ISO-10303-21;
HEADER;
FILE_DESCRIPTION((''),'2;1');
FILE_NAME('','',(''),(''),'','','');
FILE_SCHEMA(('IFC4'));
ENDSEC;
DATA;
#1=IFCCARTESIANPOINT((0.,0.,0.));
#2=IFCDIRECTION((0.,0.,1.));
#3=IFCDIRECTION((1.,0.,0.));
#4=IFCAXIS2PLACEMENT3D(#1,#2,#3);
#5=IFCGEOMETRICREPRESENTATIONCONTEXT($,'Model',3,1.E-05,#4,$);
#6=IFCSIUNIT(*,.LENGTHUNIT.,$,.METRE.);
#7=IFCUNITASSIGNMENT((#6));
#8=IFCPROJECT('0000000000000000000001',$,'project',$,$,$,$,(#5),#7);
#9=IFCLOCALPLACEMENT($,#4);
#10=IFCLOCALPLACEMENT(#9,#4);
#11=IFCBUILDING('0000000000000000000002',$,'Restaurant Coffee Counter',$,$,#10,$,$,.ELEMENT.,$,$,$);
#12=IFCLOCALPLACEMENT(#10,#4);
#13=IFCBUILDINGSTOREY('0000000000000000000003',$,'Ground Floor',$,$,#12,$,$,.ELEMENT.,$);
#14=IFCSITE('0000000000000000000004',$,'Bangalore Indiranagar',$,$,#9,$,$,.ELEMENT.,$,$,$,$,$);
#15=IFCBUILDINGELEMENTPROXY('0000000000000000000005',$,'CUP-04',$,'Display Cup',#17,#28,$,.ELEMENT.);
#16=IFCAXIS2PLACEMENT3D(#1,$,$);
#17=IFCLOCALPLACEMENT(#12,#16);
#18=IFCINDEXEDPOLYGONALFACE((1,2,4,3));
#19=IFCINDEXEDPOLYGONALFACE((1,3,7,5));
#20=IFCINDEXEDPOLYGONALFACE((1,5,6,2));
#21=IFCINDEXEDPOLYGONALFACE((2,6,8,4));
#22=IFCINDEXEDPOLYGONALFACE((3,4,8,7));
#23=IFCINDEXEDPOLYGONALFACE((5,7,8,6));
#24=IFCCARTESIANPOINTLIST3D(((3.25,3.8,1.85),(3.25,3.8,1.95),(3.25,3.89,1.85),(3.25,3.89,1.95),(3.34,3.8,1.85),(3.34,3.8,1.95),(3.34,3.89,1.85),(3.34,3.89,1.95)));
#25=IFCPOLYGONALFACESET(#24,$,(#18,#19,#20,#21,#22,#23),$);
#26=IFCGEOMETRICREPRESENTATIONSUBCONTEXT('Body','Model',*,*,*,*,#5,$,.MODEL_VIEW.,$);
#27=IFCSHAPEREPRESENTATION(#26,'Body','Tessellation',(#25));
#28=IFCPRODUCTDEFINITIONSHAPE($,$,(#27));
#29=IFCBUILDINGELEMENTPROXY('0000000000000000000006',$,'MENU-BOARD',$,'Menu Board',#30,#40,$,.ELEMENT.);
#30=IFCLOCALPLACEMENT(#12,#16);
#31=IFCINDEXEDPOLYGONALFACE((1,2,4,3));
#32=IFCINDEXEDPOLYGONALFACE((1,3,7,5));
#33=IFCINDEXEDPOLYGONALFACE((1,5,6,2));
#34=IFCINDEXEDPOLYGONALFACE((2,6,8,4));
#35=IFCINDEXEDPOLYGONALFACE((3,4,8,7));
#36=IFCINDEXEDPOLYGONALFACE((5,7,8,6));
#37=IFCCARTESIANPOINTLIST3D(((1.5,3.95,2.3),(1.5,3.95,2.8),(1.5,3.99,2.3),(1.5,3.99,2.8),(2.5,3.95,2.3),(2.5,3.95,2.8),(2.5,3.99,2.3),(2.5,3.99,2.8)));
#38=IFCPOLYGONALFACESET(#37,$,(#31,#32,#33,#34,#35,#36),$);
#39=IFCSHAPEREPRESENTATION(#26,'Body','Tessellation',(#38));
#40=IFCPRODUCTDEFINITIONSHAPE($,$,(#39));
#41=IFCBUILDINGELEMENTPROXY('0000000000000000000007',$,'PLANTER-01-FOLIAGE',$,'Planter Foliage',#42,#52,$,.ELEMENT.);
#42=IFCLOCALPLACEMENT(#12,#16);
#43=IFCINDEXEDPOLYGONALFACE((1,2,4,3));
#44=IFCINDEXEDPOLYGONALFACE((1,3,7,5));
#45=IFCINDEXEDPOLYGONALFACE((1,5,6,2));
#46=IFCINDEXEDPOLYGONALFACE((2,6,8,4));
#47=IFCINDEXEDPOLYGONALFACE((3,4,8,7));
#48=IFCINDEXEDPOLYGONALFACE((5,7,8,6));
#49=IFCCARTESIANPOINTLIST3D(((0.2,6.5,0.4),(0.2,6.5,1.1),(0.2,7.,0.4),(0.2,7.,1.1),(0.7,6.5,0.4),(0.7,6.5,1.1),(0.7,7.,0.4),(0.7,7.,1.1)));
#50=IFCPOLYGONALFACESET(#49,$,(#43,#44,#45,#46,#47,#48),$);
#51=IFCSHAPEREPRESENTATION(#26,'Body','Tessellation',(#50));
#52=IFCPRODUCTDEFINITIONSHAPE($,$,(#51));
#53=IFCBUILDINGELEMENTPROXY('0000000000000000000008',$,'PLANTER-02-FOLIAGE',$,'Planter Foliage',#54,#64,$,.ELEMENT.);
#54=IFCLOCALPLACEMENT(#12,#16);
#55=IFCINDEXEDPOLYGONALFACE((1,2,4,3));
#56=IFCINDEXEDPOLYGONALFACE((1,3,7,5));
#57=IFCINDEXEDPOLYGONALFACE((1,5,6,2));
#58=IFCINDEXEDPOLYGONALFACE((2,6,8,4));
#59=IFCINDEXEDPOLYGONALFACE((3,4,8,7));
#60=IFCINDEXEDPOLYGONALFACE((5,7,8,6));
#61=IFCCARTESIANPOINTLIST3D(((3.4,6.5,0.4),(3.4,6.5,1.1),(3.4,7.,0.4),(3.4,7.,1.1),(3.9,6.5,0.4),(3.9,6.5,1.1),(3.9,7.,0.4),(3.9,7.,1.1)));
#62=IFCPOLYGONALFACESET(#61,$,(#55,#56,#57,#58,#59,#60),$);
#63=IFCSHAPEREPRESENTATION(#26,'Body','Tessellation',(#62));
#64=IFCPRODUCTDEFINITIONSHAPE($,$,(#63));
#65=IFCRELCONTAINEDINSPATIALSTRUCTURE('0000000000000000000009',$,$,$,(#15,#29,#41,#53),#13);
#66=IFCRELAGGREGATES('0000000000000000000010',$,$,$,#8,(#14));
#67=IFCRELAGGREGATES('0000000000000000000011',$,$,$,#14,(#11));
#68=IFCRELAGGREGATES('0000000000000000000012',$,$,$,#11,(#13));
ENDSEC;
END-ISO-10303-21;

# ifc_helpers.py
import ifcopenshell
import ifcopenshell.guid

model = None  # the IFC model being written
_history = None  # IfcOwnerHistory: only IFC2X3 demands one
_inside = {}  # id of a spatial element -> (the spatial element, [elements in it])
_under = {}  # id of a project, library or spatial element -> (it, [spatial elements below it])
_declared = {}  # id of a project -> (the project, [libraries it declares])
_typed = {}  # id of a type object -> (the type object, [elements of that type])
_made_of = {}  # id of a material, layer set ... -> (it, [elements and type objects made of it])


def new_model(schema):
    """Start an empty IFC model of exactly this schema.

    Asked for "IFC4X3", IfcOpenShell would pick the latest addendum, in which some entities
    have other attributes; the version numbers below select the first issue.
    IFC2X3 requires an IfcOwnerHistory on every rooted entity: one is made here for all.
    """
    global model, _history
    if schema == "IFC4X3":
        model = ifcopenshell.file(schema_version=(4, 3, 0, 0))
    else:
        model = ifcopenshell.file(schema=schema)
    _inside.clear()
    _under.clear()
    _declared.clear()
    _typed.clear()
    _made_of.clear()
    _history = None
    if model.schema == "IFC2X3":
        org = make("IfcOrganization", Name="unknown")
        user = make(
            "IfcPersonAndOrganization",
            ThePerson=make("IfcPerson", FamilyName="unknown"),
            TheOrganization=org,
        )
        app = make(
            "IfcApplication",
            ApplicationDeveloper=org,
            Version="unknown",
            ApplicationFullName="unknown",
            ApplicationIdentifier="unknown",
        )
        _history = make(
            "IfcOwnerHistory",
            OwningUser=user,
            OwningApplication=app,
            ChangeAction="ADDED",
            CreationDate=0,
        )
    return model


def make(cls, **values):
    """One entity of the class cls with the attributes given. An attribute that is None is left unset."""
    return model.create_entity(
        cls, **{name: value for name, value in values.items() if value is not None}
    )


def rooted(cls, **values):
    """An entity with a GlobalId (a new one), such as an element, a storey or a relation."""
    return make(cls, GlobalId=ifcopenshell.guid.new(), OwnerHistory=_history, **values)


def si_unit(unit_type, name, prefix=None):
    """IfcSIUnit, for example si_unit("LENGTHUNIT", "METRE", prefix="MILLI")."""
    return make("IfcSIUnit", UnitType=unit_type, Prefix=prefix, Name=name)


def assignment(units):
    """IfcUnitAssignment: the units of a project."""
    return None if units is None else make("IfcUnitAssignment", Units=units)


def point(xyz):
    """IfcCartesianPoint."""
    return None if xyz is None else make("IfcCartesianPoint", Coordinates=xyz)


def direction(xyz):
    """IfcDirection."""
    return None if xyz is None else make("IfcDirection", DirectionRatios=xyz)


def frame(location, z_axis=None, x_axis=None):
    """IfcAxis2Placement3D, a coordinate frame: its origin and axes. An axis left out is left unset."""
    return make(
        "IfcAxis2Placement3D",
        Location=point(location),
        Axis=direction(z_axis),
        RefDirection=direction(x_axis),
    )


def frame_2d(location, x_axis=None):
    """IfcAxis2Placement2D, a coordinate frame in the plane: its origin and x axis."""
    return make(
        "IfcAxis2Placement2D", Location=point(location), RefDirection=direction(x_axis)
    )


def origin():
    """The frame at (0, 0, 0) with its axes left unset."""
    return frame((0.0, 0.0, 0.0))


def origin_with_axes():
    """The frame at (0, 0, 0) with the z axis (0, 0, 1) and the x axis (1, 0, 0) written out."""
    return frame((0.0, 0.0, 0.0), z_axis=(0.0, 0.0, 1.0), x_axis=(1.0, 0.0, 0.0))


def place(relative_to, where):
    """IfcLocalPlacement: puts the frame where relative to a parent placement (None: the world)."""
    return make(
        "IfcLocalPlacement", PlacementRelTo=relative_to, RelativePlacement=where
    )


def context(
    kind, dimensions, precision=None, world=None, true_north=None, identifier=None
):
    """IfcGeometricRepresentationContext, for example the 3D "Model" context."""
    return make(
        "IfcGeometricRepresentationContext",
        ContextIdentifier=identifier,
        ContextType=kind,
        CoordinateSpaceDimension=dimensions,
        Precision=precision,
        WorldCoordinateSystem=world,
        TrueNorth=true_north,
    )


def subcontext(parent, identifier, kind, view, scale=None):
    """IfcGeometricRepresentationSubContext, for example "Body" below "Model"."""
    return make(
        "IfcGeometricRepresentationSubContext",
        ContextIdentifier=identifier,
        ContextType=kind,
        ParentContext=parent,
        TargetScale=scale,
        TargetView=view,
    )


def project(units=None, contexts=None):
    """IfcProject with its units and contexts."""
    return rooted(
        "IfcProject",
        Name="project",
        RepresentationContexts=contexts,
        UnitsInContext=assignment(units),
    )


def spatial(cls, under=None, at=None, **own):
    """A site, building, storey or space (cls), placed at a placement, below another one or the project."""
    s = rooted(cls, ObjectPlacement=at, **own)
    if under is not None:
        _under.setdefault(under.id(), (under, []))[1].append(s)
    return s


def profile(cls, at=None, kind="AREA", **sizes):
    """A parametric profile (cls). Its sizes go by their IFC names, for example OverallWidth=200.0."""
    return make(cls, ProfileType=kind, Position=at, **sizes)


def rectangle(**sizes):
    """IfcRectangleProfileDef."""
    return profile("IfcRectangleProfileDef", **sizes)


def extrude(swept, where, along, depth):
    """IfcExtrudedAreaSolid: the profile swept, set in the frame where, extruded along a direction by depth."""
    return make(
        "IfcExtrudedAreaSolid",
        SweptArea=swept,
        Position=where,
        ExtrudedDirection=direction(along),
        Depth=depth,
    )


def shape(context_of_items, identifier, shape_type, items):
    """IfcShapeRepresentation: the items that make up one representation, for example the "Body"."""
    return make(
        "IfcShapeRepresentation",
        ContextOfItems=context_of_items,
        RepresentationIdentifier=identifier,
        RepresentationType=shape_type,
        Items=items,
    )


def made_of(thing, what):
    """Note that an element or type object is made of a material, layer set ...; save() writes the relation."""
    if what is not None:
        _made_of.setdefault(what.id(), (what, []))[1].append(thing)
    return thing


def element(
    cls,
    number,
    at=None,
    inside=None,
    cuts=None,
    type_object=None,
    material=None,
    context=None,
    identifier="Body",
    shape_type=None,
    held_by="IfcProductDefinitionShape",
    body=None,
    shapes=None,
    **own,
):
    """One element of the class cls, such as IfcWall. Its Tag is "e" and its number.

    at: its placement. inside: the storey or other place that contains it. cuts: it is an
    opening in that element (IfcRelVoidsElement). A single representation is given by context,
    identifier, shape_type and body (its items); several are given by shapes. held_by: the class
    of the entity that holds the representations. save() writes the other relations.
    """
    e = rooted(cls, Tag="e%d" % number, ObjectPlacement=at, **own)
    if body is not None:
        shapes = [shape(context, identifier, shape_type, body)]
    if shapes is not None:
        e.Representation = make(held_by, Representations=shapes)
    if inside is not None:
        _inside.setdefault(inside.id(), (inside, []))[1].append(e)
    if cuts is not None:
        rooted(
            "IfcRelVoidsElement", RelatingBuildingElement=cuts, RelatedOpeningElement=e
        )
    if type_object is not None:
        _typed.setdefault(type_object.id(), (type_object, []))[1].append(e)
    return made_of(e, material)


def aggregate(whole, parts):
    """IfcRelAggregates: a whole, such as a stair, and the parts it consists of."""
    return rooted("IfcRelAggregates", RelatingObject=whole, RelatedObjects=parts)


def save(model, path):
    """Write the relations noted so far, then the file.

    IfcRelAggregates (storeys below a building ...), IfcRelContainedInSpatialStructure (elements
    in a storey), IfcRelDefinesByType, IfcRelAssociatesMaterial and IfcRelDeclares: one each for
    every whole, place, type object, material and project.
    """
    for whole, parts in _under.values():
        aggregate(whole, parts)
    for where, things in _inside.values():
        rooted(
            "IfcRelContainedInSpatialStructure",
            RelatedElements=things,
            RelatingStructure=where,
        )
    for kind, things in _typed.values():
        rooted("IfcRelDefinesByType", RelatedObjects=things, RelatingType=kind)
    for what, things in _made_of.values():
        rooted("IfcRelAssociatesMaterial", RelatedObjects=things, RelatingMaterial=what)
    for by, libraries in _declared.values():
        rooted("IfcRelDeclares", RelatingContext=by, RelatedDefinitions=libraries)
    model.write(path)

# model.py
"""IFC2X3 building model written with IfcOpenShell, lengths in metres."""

from ifc_helpers import new_model, si_unit, frame, frame_2d, origin, origin_with_axes, place, context, subcontext, project, spatial, rectangle, extrude, element, save


model = new_model("IFC2X3")

# Units and contexts
model_context = context("Model", 3, precision=1e-05, world=origin_with_axes())
body_context = subcontext(model_context, "Body", "Model", "MODEL_VIEW")
ifc_project = project(units=[si_unit("LENGTHUNIT", "METRE")], contexts=[model_context])

# Site, building, storey
site_placement = place(None, origin_with_axes())
site = spatial("IfcSite", under=ifc_project, at=site_placement, Name="Bangalore Indiranagar", CompositionType="ELEMENT")
building_placement = place(site_placement, origin_with_axes())
building = spatial("IfcBuilding", under=site, at=building_placement, Name="Restaurant Coffee Counter", CompositionType="ELEMENT")
storey_placement = place(building_placement, origin_with_axes())
storey = spatial("IfcBuildingStorey", under=building, at=storey_placement, Name="Ground Floor", CompositionType="ELEMENT")

# Building element proxies
for number, where, z_axis, x_axis, name in (
    (1, (3.25, 3.8, 1.85), (0.0, 0.0, 1.0), (1.0, 0.0, 0.0), "CUP-04"),
):
    element("IfcBuildingElementProxy", number, at=place(storey_placement, frame(where, z_axis=z_axis, x_axis=x_axis)), inside=storey, Name=name, ObjectType="Display Cup", CompositionType="ELEMENT", context=body_context, shape_type="SweptSolid", body=[
        extrude(rectangle(XDim=0.09, YDim=0.09, at=frame_2d((0.045, 0.045))), origin(), (0.0, 0.0, 1.0), 0.1),
    ])
proxy_1_placement = place(storey_placement, frame((1.5, 3.95, 2.3), z_axis=(0.0, 0.0, 1.0), x_axis=(1.0, 0.0, 0.0)))
element("IfcBuildingElementProxy", 2, at=proxy_1_placement, inside=storey, Name="MENU-BOARD", ObjectType="Menu Board", CompositionType="ELEMENT", context=body_context, shape_type="SweptSolid", body=[
    extrude(rectangle(XDim=1.0, YDim=0.04, at=frame_2d((0.5, 0.02))), origin(), (0.0, 0.0, 1.0), 0.5),
])
for number, where, z_axis, x_axis, name in (
    (3, (0.2, 6.5, 0.4), (0.0, 0.0, 1.0), (1.0, 0.0, 0.0), "PLANTER-01-FOLIAGE"),
    (4, (3.4, 6.5, 0.4), (0.0, 0.0, 1.0), (1.0, 0.0, 0.0), "PLANTER-02-FOLIAGE"),
):
    element("IfcBuildingElementProxy", number, at=place(storey_placement, frame(where, z_axis=z_axis, x_axis=x_axis)), inside=storey, Name=name, ObjectType="Planter Foliage", CompositionType="ELEMENT", context=body_context, shape_type="SweptSolid", body=[
        extrude(rectangle(XDim=0.5, YDim=0.5, at=frame_2d((0.25, 0.25))), origin(), (0.0, 0.0, 1.0), 0.7),
    ])

save(model, "model.ifc")
